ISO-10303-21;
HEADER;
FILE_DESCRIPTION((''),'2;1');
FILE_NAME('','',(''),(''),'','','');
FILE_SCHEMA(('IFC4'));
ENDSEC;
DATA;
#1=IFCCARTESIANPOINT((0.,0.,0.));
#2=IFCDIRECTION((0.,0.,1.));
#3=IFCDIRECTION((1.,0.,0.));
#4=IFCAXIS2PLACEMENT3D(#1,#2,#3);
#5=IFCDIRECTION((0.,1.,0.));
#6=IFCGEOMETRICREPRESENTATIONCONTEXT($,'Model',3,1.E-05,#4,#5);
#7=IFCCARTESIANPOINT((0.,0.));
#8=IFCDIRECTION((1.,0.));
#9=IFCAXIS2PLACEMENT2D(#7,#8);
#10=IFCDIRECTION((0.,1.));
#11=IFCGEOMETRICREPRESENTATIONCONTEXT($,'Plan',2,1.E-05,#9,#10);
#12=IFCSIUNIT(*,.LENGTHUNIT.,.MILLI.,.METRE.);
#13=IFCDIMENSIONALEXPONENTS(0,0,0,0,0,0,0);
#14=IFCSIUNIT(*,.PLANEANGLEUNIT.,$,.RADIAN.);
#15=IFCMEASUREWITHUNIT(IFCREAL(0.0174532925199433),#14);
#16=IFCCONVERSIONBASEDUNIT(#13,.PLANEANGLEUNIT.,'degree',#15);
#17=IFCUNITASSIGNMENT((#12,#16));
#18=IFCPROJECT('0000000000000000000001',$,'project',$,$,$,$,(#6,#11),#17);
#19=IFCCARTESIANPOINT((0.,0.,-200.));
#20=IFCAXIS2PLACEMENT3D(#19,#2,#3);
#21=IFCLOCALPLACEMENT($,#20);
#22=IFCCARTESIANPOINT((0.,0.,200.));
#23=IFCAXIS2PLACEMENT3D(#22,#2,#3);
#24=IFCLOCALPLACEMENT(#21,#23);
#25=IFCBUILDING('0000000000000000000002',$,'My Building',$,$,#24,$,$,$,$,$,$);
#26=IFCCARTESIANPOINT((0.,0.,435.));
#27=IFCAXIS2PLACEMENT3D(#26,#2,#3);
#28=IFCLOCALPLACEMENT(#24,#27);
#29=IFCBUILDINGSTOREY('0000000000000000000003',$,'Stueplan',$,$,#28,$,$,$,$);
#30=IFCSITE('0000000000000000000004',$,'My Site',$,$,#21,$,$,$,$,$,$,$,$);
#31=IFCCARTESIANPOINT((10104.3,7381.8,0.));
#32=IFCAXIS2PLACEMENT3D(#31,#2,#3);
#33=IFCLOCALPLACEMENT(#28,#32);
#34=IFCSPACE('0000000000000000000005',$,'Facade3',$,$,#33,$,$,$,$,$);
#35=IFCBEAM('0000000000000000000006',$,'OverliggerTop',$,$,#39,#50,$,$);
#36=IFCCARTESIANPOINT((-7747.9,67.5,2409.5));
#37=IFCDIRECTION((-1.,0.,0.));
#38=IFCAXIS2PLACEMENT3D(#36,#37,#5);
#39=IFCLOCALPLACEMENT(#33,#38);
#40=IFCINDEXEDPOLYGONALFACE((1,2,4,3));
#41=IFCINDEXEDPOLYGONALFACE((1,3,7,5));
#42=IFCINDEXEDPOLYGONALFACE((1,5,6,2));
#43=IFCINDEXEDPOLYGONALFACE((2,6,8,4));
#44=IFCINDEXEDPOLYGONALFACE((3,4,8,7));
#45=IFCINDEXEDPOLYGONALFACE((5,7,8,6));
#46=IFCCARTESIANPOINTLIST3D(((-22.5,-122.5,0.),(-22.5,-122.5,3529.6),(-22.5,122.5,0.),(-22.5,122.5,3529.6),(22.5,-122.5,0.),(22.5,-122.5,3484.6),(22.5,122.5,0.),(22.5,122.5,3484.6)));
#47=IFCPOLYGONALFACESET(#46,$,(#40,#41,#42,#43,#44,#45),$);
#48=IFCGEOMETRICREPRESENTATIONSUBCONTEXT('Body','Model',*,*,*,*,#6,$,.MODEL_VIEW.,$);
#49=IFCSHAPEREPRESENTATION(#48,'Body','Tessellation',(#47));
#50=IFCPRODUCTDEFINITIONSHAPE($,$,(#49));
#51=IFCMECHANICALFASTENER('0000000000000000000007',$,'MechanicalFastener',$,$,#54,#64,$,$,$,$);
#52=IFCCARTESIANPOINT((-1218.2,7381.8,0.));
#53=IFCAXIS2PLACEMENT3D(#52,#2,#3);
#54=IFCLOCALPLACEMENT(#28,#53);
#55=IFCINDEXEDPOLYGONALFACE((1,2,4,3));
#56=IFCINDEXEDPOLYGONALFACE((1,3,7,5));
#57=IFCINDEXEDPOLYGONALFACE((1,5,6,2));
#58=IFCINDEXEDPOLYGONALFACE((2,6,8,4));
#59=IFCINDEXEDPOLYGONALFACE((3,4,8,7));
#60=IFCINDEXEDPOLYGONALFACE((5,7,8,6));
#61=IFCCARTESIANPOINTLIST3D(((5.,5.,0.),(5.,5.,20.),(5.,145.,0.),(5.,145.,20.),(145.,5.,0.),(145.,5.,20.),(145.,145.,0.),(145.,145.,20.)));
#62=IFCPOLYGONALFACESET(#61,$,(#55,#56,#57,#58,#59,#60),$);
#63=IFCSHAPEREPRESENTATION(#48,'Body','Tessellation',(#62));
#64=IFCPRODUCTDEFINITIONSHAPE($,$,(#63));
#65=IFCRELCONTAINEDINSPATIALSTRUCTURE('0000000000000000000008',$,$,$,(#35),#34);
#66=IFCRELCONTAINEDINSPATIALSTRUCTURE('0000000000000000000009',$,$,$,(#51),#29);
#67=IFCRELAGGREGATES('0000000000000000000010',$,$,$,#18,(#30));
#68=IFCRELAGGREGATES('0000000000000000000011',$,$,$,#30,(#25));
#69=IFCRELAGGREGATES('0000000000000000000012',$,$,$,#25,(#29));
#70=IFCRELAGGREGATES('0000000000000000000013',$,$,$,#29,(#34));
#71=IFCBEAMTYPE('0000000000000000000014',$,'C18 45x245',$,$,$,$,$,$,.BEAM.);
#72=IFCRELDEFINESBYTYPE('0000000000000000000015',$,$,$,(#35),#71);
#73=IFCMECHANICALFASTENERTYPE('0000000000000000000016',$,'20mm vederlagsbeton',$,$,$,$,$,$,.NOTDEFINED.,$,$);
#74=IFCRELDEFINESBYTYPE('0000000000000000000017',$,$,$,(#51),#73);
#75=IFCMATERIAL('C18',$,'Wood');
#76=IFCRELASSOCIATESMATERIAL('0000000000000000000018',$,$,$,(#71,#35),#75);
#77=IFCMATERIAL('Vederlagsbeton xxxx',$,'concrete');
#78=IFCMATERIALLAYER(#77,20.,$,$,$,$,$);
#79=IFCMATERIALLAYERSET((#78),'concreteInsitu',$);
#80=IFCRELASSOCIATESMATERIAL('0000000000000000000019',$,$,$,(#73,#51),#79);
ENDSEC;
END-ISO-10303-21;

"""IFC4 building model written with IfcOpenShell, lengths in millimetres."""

from ifc_helpers import new_model, entity, si_unit, converted_unit, direction, frame, origin_with_axes, origin_2d_with_axis, place, context, subcontext, project, spatial, indexed_curve, rectangle, outline, extrude, clip, halfspace, material, layer, layer_set, layer_usage, material_profile, profile_set, profile_usage, type_object, element, save


model = new_model("IFC4")

# Units and contexts
model_context = context("Model", 3, precision=1e-05, world=origin_with_axes(), true_north=direction((0.0, 1.0, 0.0)))
plan_context = context("Plan", 2, precision=1e-05, world=origin_2d_with_axis(), true_north=direction((0.0, 1.0)))
body_context_1 = subcontext(model_context, "Body", "Model", "MODEL_VIEW")
ifc_project = project(units=[si_unit("LENGTHUNIT", "METRE", prefix="MILLI"), converted_unit("PLANEANGLEUNIT", "degree", entity("IfcReal", 0.0174532925199433), si_unit("PLANEANGLEUNIT", "RADIAN"), dimensions=[0, 0, 0, 0, 0, 0, 0])], contexts=[model_context, plan_context])

# Site, building, storey
site_placement = place(None, frame((0.0, 0.0, -200.0), z_axis=(0.0, 0.0, 1.0), x_axis=(1.0, 0.0, 0.0)))
site = spatial("IfcSite", under=ifc_project, at=site_placement, Name="My Site")
building_placement = place(site_placement, frame((0.0, 0.0, 200.0), z_axis=(0.0, 0.0, 1.0), x_axis=(1.0, 0.0, 0.0)))
building = spatial("IfcBuilding", under=site, at=building_placement, Name="My Building")
storey_placement = place(building_placement, frame((0.0, 0.0, 435.0), z_axis=(0.0, 0.0, 1.0), x_axis=(1.0, 0.0, 0.0)))
storey = spatial("IfcBuildingStorey", under=building, at=storey_placement, Name="Stueplan")

# Shared definitions
ifc_material_1 = material(Name="C18", Category="Wood")

# Shared definitions
ifc_material_profile_1 = material_profile(ifc_material_1, rectangle(XDim=45.0, YDim=245.0), Name="concrete")
ifc_profile_set_1 = profile_set([ifc_material_profile_1], Name="woodStructural")
beam_type_1 = type_object("IfcBeamType", Name="C18 45x245", PredefinedType="BEAM", material=ifc_profile_set_1)

# Shared definitions
space_1_placement = place(storey_placement, frame((10104.3, 7381.8, 0.0), z_axis=(0.0, 0.0, 1.0), x_axis=(1.0, 0.0, 0.0)))
space_1 = spatial("IfcSpace", under=storey, at=space_1_placement, Name="Facade3")

# Beam
ifc_profile_usage_1 = profile_usage(ifc_profile_set_1)
beam_1_placement = place(space_1_placement, frame((-7747.9, 67.5, 2409.5), z_axis=(-1.0, 0.0, 0.0), x_axis=(0.0, 1.0, 0.0)))
element("IfcBeam", 1, at=beam_1_placement, inside=space_1, type_object=beam_type_1, material=ifc_profile_usage_1, Name="OverliggerTop", context=body_context_1, shape_type="Clipping", body=[
    clip(extrude(rectangle(XDim=45.0, YDim=245.0), origin_with_axes(), (0.0, 0.0, 1.0), 3529.6), halfspace(frame((-22.5, 2844.5, 3529.6), z_axis=(0.707103, 0.0, 0.70711), x_axis=(0.0, -1.0, 0.0)), False)),
])

# Mechanical fastener
ifc_material_2 = material(Name="Vederlagsbeton xxxx", Category="concrete")
ifc_layer_1 = layer(ifc_material_2, 20.0)
ifc_layer_set_1 = layer_set([ifc_layer_1], Name="concreteInsitu")
ifc_layer_usage_1 = layer_usage(ifc_layer_set_1, "AXIS3", "POSITIVE", 0.0)
mechanical_fastener_type_1 = type_object("IfcMechanicalFastenerType", Name="20mm vederlagsbeton", PredefinedType="NOTDEFINED", material=ifc_layer_set_1)
mechanical_fastener_1_placement = place(storey_placement, frame((-1218.2, 7381.8, 0.0), z_axis=(0.0, 0.0, 1.0), x_axis=(1.0, 0.0, 0.0)))
element("IfcMechanicalFastener", 2, at=mechanical_fastener_1_placement, inside=storey, type_object=mechanical_fastener_type_1, material=ifc_layer_usage_1, Name="MechanicalFastener", context=body_context_1, shape_type="SweptSolid", body=[
    extrude(outline(indexed_curve([(145.0, 5.0), (145.0, 145.0), (5.0, 145.0), (5.0, 5.0), (145.0, 5.0)])), None, (0.0, 0.0, 1.0), 20.0),
])

save(model, "model.ifc")
